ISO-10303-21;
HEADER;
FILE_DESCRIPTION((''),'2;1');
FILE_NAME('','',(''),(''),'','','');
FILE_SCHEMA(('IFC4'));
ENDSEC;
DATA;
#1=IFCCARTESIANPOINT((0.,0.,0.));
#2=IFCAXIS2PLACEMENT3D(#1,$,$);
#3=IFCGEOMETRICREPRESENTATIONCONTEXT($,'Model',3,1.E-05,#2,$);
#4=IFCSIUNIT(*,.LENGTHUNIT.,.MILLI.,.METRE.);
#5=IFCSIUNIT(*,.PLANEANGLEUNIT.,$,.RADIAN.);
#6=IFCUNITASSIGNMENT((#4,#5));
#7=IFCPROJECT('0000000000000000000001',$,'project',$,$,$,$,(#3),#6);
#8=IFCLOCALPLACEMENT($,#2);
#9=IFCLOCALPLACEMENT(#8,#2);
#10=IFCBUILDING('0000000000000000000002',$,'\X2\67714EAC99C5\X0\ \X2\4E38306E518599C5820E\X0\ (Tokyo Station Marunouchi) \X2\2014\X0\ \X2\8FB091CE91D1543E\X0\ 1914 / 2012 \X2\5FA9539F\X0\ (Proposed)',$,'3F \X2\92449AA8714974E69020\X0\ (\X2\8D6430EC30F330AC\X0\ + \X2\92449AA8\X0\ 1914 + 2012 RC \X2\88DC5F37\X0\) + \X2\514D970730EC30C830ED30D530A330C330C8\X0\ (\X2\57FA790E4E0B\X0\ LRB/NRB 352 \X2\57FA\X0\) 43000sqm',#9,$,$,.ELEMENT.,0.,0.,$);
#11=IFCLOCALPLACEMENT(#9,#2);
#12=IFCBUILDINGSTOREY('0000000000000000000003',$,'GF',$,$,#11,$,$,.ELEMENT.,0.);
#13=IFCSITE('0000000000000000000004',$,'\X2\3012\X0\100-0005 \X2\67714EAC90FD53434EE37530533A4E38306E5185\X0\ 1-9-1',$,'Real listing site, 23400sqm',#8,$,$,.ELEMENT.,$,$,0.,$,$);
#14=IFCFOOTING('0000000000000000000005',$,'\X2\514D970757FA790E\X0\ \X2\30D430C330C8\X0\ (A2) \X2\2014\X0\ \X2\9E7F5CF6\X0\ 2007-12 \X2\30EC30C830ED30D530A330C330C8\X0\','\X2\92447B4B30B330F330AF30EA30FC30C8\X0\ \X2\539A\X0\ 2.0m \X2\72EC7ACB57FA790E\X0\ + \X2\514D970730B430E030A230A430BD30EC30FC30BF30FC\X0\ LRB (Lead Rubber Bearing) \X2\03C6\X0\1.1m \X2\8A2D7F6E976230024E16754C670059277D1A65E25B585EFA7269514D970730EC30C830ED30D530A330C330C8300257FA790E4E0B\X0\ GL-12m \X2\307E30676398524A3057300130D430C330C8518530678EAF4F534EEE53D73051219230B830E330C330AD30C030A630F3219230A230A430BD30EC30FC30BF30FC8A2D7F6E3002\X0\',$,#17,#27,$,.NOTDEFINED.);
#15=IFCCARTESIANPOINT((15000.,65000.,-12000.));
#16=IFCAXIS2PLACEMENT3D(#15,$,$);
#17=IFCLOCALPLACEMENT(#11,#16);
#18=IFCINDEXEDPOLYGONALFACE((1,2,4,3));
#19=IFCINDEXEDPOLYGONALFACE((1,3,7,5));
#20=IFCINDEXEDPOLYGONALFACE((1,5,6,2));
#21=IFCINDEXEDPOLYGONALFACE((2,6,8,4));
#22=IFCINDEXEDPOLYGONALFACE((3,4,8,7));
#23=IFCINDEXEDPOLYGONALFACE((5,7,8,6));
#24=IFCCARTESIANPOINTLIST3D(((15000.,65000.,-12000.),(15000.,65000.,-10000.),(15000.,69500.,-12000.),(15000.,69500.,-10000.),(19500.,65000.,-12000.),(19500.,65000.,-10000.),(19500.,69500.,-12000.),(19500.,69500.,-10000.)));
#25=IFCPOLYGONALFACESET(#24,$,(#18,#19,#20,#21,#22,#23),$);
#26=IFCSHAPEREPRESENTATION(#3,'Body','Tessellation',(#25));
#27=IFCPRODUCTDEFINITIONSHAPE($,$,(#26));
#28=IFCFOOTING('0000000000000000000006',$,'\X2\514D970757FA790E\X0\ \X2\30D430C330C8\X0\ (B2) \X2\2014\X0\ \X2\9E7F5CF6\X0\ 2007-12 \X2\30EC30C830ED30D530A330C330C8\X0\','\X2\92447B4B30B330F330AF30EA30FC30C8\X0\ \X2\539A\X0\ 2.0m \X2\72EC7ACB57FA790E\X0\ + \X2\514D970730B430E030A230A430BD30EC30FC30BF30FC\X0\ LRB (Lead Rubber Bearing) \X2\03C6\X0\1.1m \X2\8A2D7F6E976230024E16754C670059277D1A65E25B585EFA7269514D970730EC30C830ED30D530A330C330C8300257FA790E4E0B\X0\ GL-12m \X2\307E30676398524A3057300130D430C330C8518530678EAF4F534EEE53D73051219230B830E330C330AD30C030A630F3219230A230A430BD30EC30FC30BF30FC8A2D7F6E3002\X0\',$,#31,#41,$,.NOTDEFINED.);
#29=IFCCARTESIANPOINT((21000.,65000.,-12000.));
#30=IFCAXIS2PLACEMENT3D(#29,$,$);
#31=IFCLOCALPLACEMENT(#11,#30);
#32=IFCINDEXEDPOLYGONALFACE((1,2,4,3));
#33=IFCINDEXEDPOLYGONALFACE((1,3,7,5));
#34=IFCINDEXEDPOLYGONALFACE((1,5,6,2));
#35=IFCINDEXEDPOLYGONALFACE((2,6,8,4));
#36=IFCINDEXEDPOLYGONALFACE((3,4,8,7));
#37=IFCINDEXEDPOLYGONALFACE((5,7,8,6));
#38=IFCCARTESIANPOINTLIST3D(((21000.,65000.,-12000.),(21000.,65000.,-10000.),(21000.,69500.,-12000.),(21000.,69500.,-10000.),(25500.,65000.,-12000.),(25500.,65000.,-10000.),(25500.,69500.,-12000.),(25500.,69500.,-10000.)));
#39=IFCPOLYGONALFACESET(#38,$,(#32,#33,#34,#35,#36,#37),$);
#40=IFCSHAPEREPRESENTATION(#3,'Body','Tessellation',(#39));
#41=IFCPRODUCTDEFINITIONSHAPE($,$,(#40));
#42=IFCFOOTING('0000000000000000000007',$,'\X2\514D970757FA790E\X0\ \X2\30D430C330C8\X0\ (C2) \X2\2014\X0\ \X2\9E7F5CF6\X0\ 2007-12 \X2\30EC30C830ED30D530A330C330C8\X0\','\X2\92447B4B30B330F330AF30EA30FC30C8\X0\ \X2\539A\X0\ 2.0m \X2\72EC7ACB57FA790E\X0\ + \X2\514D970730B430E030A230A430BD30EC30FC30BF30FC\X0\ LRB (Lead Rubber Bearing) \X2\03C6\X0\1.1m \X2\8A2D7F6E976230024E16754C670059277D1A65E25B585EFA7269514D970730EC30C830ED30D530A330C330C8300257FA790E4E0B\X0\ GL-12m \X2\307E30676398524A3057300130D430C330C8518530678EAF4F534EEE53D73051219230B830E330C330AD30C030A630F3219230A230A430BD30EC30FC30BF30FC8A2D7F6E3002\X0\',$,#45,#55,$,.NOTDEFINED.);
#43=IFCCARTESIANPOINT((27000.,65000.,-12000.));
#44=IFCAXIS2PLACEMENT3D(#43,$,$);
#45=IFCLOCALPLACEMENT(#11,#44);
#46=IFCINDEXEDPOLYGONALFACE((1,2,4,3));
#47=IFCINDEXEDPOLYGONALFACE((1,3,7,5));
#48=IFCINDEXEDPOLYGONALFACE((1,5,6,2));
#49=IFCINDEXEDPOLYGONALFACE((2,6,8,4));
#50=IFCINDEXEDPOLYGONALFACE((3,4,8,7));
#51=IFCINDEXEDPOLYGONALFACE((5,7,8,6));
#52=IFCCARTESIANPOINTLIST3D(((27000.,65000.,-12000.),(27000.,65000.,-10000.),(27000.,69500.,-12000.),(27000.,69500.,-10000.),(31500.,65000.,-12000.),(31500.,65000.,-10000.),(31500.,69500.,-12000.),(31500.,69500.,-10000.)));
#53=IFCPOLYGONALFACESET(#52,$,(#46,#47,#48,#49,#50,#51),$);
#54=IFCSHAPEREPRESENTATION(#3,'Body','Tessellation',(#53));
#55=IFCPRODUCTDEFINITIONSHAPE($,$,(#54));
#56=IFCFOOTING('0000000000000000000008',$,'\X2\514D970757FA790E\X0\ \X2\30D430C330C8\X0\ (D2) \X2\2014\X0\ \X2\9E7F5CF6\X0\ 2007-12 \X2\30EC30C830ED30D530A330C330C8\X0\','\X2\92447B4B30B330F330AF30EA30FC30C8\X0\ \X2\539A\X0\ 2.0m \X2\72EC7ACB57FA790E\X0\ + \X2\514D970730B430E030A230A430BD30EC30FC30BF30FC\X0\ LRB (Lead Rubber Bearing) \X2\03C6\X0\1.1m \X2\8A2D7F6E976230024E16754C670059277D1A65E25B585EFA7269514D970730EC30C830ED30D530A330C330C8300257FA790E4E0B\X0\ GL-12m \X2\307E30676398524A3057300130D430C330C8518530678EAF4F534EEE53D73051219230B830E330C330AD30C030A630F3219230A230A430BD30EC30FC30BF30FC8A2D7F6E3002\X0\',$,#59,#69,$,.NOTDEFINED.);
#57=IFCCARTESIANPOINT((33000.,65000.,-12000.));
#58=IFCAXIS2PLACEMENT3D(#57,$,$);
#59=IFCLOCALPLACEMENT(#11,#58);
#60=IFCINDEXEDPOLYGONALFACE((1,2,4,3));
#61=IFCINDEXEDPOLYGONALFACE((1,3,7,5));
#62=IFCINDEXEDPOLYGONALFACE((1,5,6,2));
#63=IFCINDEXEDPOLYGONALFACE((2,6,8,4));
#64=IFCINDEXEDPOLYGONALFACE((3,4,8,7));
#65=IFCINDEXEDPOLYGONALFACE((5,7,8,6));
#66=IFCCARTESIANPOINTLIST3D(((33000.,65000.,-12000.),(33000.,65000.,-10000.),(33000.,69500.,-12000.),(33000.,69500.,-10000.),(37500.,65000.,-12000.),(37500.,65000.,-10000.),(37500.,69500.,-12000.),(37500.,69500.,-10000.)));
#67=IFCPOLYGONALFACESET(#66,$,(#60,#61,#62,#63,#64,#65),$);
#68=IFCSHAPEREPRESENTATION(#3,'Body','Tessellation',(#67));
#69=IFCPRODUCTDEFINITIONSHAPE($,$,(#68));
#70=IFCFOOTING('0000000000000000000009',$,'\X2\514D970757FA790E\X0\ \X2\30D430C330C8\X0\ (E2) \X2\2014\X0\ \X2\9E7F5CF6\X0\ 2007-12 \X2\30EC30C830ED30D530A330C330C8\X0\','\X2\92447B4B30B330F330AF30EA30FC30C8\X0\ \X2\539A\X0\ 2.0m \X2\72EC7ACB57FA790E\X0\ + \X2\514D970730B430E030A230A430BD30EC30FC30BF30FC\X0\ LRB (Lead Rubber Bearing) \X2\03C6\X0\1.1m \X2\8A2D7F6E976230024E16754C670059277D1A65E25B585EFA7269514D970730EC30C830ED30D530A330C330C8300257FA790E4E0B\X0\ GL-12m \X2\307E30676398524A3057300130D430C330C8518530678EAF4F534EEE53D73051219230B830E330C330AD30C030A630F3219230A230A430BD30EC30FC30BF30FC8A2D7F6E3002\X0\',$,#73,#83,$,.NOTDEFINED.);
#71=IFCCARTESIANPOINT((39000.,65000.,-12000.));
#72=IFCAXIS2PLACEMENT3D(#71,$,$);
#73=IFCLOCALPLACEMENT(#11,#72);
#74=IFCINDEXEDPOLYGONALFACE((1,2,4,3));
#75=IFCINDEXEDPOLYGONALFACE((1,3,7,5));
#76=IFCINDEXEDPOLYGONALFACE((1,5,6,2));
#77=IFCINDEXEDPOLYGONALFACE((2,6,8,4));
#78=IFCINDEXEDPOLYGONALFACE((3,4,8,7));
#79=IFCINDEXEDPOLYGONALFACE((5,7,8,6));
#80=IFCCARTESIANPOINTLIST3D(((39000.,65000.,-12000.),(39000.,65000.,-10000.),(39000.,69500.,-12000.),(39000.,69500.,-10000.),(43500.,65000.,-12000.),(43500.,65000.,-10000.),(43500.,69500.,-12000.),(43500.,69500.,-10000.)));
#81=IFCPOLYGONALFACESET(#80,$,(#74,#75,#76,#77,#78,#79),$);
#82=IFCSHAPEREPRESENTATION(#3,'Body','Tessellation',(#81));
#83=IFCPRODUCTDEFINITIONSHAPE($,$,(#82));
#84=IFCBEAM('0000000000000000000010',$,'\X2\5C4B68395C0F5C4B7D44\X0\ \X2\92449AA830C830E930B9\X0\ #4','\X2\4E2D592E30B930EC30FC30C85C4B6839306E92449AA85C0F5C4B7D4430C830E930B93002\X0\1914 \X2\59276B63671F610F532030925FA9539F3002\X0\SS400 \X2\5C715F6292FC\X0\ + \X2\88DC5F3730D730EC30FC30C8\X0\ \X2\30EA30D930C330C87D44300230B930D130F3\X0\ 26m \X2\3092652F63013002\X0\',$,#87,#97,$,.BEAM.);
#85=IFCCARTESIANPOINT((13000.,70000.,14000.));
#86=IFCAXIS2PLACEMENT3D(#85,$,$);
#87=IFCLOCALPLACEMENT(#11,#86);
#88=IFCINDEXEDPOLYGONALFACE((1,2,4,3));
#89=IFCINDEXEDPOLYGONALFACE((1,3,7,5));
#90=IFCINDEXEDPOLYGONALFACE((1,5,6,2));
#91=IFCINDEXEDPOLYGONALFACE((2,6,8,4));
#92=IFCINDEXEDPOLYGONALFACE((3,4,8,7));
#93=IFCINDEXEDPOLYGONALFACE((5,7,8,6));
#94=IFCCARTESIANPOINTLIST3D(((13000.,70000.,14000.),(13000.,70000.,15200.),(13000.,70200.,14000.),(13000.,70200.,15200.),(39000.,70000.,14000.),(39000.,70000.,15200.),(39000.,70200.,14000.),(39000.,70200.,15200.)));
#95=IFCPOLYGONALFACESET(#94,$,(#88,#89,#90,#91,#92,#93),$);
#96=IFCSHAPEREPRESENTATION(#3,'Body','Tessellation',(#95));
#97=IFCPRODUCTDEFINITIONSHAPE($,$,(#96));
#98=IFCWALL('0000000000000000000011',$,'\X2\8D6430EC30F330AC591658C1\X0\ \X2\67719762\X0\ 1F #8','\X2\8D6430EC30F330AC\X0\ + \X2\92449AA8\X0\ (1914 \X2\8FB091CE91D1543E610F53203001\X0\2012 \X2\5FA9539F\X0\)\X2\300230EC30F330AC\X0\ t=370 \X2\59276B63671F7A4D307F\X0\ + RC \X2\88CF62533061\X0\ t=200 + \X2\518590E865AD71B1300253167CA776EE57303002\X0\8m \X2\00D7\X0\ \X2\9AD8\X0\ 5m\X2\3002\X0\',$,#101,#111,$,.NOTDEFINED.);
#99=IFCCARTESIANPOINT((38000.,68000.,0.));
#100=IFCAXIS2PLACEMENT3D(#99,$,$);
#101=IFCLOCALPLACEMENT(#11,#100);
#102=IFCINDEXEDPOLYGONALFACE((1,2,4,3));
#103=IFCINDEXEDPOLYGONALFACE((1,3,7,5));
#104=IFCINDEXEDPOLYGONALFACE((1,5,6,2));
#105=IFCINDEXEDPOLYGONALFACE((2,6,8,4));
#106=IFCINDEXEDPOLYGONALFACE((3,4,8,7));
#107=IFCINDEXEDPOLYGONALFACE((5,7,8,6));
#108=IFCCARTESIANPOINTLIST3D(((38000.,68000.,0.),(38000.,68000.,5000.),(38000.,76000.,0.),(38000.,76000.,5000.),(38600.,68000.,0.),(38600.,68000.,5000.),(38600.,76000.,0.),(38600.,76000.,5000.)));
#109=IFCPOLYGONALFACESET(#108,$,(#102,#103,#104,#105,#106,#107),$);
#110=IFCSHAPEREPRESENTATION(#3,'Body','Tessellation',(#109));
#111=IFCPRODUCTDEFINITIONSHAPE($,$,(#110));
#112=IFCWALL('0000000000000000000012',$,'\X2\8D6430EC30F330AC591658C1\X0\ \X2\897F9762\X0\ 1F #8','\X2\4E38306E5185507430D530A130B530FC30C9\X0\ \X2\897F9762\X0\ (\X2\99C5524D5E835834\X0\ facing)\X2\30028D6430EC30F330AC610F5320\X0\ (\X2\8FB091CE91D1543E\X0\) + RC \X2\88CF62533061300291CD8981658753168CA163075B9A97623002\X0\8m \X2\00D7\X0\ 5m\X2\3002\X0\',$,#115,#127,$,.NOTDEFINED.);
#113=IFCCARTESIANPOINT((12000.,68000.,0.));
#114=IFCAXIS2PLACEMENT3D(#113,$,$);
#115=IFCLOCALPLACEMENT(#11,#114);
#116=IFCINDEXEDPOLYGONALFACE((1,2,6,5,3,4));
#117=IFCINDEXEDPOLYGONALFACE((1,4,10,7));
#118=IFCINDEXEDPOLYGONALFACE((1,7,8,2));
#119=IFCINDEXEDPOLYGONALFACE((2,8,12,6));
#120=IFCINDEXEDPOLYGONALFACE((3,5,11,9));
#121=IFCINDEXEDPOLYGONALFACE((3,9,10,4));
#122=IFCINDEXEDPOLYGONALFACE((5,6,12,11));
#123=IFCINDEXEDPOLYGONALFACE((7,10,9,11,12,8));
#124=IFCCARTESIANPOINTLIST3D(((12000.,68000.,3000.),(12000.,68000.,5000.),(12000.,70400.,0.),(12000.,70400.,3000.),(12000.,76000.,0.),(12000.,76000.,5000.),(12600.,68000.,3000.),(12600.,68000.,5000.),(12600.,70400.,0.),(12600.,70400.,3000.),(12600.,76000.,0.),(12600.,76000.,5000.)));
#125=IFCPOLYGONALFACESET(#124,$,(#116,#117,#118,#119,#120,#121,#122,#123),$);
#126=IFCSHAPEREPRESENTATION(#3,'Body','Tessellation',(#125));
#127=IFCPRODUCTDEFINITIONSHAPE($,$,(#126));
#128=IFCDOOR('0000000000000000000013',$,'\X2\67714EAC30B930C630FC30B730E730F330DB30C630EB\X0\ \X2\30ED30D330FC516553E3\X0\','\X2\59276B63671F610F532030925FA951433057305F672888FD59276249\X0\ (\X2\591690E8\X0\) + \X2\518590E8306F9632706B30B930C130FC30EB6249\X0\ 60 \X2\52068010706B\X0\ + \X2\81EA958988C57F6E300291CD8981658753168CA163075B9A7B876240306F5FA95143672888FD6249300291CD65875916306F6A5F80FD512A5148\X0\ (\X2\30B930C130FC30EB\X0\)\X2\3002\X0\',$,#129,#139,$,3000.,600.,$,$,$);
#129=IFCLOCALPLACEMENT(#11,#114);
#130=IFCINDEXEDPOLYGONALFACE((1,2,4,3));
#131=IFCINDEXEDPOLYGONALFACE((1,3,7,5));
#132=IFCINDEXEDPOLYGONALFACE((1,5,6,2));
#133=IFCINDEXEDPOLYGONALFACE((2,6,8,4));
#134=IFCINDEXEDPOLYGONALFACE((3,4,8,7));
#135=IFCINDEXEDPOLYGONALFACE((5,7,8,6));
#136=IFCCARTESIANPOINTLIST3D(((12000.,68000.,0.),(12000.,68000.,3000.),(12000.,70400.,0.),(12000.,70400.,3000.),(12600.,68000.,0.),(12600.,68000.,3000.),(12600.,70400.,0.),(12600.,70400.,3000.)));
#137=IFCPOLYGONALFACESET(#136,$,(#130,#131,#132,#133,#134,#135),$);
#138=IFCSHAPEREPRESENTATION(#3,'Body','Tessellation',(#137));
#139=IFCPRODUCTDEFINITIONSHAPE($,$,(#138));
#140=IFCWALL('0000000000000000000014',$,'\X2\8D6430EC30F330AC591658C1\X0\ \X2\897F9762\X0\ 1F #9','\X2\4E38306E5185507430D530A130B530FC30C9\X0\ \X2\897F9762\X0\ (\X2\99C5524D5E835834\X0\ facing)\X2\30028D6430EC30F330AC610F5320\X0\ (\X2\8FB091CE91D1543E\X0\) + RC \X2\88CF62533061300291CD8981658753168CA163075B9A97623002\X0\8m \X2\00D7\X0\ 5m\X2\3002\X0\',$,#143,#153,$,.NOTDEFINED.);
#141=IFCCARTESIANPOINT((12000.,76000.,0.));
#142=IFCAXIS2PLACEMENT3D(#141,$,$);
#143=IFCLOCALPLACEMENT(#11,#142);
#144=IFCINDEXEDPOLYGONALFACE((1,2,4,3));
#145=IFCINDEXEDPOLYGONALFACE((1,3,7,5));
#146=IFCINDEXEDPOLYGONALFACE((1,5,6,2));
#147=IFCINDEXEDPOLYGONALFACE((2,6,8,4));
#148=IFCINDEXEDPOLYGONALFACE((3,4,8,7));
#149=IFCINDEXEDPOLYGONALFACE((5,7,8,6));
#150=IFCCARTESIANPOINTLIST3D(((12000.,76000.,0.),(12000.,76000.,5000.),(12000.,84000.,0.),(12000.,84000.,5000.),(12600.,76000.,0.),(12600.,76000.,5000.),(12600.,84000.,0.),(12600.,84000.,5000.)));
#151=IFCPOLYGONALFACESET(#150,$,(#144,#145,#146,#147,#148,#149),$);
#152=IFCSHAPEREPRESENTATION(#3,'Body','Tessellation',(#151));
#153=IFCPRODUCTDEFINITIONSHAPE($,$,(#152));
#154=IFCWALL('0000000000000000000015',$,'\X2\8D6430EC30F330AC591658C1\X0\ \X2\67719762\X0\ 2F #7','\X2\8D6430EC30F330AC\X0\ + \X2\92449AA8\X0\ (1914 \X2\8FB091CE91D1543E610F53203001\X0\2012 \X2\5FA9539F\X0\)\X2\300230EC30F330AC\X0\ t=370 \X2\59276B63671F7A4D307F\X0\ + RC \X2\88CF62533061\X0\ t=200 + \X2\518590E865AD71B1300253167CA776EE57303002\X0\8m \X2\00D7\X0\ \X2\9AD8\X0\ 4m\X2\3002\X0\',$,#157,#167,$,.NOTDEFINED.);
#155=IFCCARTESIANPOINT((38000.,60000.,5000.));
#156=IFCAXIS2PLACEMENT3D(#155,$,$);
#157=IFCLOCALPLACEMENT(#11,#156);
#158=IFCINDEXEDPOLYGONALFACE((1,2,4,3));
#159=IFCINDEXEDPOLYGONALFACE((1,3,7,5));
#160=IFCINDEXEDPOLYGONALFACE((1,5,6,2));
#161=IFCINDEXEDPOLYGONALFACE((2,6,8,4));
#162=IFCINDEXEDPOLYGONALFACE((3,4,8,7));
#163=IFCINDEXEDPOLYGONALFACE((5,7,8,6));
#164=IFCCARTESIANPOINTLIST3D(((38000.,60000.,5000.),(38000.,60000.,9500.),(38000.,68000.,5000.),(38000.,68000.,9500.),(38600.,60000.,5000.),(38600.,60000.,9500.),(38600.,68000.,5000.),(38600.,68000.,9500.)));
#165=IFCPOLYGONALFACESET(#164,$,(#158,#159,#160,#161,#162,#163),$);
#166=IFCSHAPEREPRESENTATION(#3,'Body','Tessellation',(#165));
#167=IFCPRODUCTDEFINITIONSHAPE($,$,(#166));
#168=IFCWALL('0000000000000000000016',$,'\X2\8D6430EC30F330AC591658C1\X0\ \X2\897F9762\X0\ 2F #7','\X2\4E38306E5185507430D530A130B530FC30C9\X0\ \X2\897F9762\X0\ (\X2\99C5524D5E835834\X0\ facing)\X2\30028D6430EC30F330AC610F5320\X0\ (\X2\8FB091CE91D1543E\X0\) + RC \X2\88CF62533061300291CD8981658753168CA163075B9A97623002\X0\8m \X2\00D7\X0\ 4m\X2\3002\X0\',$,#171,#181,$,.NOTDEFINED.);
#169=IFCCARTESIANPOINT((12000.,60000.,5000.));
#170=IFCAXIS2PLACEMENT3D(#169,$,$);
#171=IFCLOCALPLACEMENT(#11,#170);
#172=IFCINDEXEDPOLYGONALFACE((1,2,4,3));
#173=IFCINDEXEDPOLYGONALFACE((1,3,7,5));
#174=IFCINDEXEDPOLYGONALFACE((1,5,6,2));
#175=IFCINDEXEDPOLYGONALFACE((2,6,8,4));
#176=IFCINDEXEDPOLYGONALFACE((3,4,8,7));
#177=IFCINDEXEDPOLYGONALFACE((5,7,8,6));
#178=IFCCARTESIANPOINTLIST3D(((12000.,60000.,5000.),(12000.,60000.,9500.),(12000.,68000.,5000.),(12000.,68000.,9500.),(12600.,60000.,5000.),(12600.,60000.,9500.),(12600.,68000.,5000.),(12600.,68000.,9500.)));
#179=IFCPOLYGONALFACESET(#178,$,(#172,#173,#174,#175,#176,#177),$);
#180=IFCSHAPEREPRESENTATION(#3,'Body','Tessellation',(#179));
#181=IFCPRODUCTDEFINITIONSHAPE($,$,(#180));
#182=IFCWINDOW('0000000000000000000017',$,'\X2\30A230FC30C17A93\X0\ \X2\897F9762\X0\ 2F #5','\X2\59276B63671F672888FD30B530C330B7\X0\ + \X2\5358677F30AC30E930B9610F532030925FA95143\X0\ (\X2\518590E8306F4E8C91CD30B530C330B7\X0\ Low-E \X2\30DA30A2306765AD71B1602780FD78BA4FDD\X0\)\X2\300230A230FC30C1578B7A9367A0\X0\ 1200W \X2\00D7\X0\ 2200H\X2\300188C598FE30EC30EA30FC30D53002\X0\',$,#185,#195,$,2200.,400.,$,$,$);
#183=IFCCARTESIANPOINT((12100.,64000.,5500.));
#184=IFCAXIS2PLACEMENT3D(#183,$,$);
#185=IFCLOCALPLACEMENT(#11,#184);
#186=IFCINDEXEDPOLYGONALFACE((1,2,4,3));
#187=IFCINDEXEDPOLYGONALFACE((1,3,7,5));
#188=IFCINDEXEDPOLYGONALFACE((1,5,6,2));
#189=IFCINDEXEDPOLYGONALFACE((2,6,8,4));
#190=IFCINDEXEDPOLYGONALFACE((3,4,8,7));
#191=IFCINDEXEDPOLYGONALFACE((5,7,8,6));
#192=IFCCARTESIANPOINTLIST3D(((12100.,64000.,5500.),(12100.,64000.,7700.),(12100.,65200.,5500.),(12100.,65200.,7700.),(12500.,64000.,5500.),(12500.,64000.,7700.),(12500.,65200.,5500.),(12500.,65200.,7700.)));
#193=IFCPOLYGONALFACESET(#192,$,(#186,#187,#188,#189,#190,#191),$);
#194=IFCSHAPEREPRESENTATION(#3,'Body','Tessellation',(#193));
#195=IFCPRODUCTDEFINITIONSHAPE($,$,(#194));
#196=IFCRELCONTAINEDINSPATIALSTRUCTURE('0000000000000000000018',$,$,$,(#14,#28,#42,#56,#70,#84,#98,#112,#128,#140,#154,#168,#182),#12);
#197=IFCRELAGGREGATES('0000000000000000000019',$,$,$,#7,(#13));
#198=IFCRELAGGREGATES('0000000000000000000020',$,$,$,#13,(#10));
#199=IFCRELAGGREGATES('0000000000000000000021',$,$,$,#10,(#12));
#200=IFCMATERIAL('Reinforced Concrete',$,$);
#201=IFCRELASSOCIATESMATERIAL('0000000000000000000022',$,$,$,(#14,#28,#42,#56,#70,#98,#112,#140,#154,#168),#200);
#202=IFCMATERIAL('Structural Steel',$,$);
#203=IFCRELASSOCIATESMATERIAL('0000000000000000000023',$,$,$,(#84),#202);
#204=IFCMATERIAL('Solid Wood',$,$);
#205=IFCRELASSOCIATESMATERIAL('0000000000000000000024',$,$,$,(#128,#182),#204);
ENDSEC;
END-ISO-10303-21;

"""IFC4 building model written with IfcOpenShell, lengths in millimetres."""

from ifc_helpers import new_model, si_unit, frame, frame_2d, origin, place, context, project, spatial, rectangle, extrude, material, element, fill, save


model = new_model("IFC4")

# Units and contexts
model_context = context("Model", 3, precision=1e-05, world=origin())
ifc_project = project(units=[si_unit("LENGTHUNIT", "METRE", prefix="MILLI"), si_unit("PLANEANGLEUNIT", "RADIAN")], contexts=[model_context])

# Site, building, storey
site_placement = place(None, origin())
site = spatial("IfcSite", under=ifc_project, at=site_placement, Name="〒100-0005 東京都千代田区丸の内 1-9-1", ObjectType="Real listing site, 23400sqm", CompositionType="ELEMENT", RefElevation=0.0)
building_placement = place(site_placement, origin())
building = spatial("IfcBuilding", under=site, at=building_placement, Name="東京駅 丸の内駅舎 (Tokyo Station Marunouchi) — 辰野金吾 1914 / 2012 復原 (Proposed)", ObjectType="3F 鉄骨煉瓦造 (赤レンガ + 鉄骨 1914 + 2012 RC 補強) + 免震レトロフィット (基礎下 LRB/NRB 352 基) 43000sqm", CompositionType="ELEMENT", ElevationOfRefHeight=0.0, ElevationOfTerrain=0.0)
storey_placement = place(building_placement, origin())
storey = spatial("IfcBuildingStorey", under=building, at=storey_placement, Name="GF", CompositionType="ELEMENT", Elevation=0.0)

# Footings
ifc_material_1 = material(Name="Reinforced Concrete")
footing_1_placement = place(storey_placement, frame((15000.0, 65000.0, -12000.0)))
element("IfcFooting", 1, at=footing_1_placement, inside=storey, material=ifc_material_1, Name="免震基礎 ピット (A2) — 鹿島 2007-12 レトロフィット", Description="鉄筋コンクリート 厚 2.0m 独立基礎 + 免震ゴムアイソレーター LRB (Lead Rubber Bearing) φ1.1m 設置面。世界最大級既存建物免震レトロフィット。基礎下 GL-12m まで掘削し、ピット内で躯体仮受け→ジャッキダウン→アイソレーター設置。", PredefinedType="NOTDEFINED", context=model_context, shape_type="SweptSolid", body=[
    extrude(rectangle(XDim=4500.0, YDim=4500.0, at=frame_2d((2250.0, 2250.0))), frame((15000.0, 65000.0, -12000.0)), (0.0, 0.0, 1.0), 2000.0),
])
footing_2_placement = place(storey_placement, frame((21000.0, 65000.0, -12000.0)))
element("IfcFooting", 2, at=footing_2_placement, inside=storey, material=ifc_material_1, Name="免震基礎 ピット (B2) — 鹿島 2007-12 レトロフィット", Description="鉄筋コンクリート 厚 2.0m 独立基礎 + 免震ゴムアイソレーター LRB (Lead Rubber Bearing) φ1.1m 設置面。世界最大級既存建物免震レトロフィット。基礎下 GL-12m まで掘削し、ピット内で躯体仮受け→ジャッキダウン→アイソレーター設置。", PredefinedType="NOTDEFINED", context=model_context, shape_type="SweptSolid", body=[
    extrude(rectangle(XDim=4500.0, YDim=4500.0, at=frame_2d((2250.0, 2250.0))), frame((21000.0, 65000.0, -12000.0)), (0.0, 0.0, 1.0), 2000.0),
])
footing_3_placement = place(storey_placement, frame((27000.0, 65000.0, -12000.0)))
element("IfcFooting", 3, at=footing_3_placement, inside=storey, material=ifc_material_1, Name="免震基礎 ピット (C2) — 鹿島 2007-12 レトロフィット", Description="鉄筋コンクリート 厚 2.0m 独立基礎 + 免震ゴムアイソレーター LRB (Lead Rubber Bearing) φ1.1m 設置面。世界最大級既存建物免震レトロフィット。基礎下 GL-12m まで掘削し、ピット内で躯体仮受け→ジャッキダウン→アイソレーター設置。", PredefinedType="NOTDEFINED", context=model_context, shape_type="SweptSolid", body=[
    extrude(rectangle(XDim=4500.0, YDim=4500.0, at=frame_2d((2250.0, 2250.0))), frame((27000.0, 65000.0, -12000.0)), (0.0, 0.0, 1.0), 2000.0),
])
footing_4_placement = place(storey_placement, frame((33000.0, 65000.0, -12000.0)))
element("IfcFooting", 4, at=footing_4_placement, inside=storey, material=ifc_material_1, Name="免震基礎 ピット (D2) — 鹿島 2007-12 レトロフィット", Description="鉄筋コンクリート 厚 2.0m 独立基礎 + 免震ゴムアイソレーター LRB (Lead Rubber Bearing) φ1.1m 設置面。世界最大級既存建物免震レトロフィット。基礎下 GL-12m まで掘削し、ピット内で躯体仮受け→ジャッキダウン→アイソレーター設置。", PredefinedType="NOTDEFINED", context=model_context, shape_type="SweptSolid", body=[
    extrude(rectangle(XDim=4500.0, YDim=4500.0, at=frame_2d((2250.0, 2250.0))), frame((33000.0, 65000.0, -12000.0)), (0.0, 0.0, 1.0), 2000.0),
])
footing_5_placement = place(storey_placement, frame((39000.0, 65000.0, -12000.0)))
element("IfcFooting", 5, at=footing_5_placement, inside=storey, material=ifc_material_1, Name="免震基礎 ピット (E2) — 鹿島 2007-12 レトロフィット", Description="鉄筋コンクリート 厚 2.0m 独立基礎 + 免震ゴムアイソレーター LRB (Lead Rubber Bearing) φ1.1m 設置面。世界最大級既存建物免震レトロフィット。基礎下 GL-12m まで掘削し、ピット内で躯体仮受け→ジャッキダウン→アイソレーター設置。", PredefinedType="NOTDEFINED", context=model_context, shape_type="SweptSolid", body=[
    extrude(rectangle(XDim=4500.0, YDim=4500.0, at=frame_2d((2250.0, 2250.0))), frame((39000.0, 65000.0, -12000.0)), (0.0, 0.0, 1.0), 2000.0),
])

# Beam
ifc_material_2 = material(Name="Structural Steel")
beam_placement = place(storey_placement, frame((13000.0, 70000.0, 14000.0)))
element("IfcBeam", 6, at=beam_placement, inside=storey, material=ifc_material_2, Name="屋根小屋組 鉄骨トラス #4", Description="中央スレート屋根の鉄骨小屋組トラス。1914 大正期意匠を復原。SS400 山形鋼 + 補強プレート リベット組。スパン 26m を支持。", PredefinedType="BEAM", context=model_context, shape_type="SweptSolid", body=[
    extrude(rectangle(XDim=26000.0, YDim=200.0, at=frame_2d((13000.0, 100.0))), frame((13000.0, 70000.0, 14000.0)), (0.0, 0.0, 1.0), 1200.0),
])

# Wall
wall_1_placement = place(storey_placement, frame((38000.0, 68000.0, 0.0)))
element("IfcWall", 7, at=wall_1_placement, inside=storey, material=ifc_material_1, Name="赤レンガ外壁 東面 1F #8", Description="赤レンガ + 鉄骨 (1914 辰野金吾意匠、2012 復原)。レンガ t=370 大正期積み + RC 裏打ち t=200 + 内部断熱。化粧目地。8m × 高 5m。", PredefinedType="NOTDEFINED", context=model_context, shape_type="SweptSolid", body=[
    extrude(rectangle(XDim=600.0, YDim=8000.0, at=frame_2d((300.0, 4000.0))), frame((38000.0, 68000.0, 0.0)), (0.0, 0.0, 1.0), 5000.0),
])

# Wall, opening, door
wall_2_placement = place(storey_placement, frame((12000.0, 68000.0, 0.0)))
wall_2 = element("IfcWall", 8, at=wall_2_placement, inside=storey, material=ifc_material_1, Name="赤レンガ外壁 西面 1F #8", Description="丸の内側ファサード 西面 (駅前広場 facing)。赤レンガ意匠 (辰野金吾) + RC 裏打ち。重要文化財指定面。8m × 5m。", PredefinedType="NOTDEFINED", context=model_context, shape_type="SweptSolid", body=[
    extrude(rectangle(XDim=600.0, YDim=8000.0, at=frame_2d((300.0, 4000.0))), frame((12000.0, 68000.0, 0.0)), (0.0, 0.0, 1.0), 5000.0),
])
opening_1_placement = place(storey_placement, frame((12000.0, 68000.0, 0.0)))
opening_1 = element("IfcOpeningElement", 9, at=opening_1_placement, cuts=wall_2, PredefinedType="NOTDEFINED", context=model_context, shape_type="SweptSolid", body=[
    extrude(rectangle(XDim=600.0, YDim=2400.0, at=frame_2d((300.0, 1200.0))), frame((12000.0, 68000.0, 0.0)), (0.0, 0.0, 1.0), 3000.0),
])
ifc_material_3 = material(Name="Solid Wood")
door_placement = place(storey_placement, frame((12000.0, 68000.0, 0.0)))
door = element("IfcDoor", 10, at=door_placement, inside=storey, material=ifc_material_3, Name="東京ステーションホテル ロビー入口", Description="大正期意匠を復元した木製大扉 (外部) + 内部は防火スチール扉 60 分耐火 + 自閉装置。重要文化財指定箇所は復元木製扉。重文外は機能優先 (スチール)。", OverallHeight=3000.0, OverallWidth=600.0, context=model_context, shape_type="SweptSolid", body=[
    extrude(rectangle(XDim=600.0, YDim=2400.0, at=frame_2d((300.0, 1200.0))), frame((12000.0, 68000.0, 0.0)), (0.0, 0.0, 1.0), 3000.0),
])
fill(opening_1, door)

# Walls
wall_3_placement = place(storey_placement, frame((12000.0, 76000.0, 0.0)))
element("IfcWall", 11, at=wall_3_placement, inside=storey, material=ifc_material_1, Name="赤レンガ外壁 西面 1F #9", Description="丸の内側ファサード 西面 (駅前広場 facing)。赤レンガ意匠 (辰野金吾) + RC 裏打ち。重要文化財指定面。8m × 5m。", PredefinedType="NOTDEFINED", context=model_context, shape_type="SweptSolid", body=[
    extrude(rectangle(XDim=600.0, YDim=8000.0, at=frame_2d((300.0, 4000.0))), frame((12000.0, 76000.0, 0.0)), (0.0, 0.0, 1.0), 5000.0),
])
wall_4_placement = place(storey_placement, frame((38000.0, 60000.0, 5000.0)))
element("IfcWall", 12, at=wall_4_placement, inside=storey, material=ifc_material_1, Name="赤レンガ外壁 東面 2F #7", Description="赤レンガ + 鉄骨 (1914 辰野金吾意匠、2012 復原)。レンガ t=370 大正期積み + RC 裏打ち t=200 + 内部断熱。化粧目地。8m × 高 4m。", PredefinedType="NOTDEFINED", context=model_context, shape_type="SweptSolid", body=[
    extrude(rectangle(XDim=600.0, YDim=8000.0, at=frame_2d((300.0, 4000.0))), frame((38000.0, 60000.0, 5000.0)), (0.0, 0.0, 1.0), 4500.0),
])

# Wall, opening, window
wall_5_placement = place(storey_placement, frame((12000.0, 60000.0, 5000.0)))
wall_5 = element("IfcWall", 13, at=wall_5_placement, inside=storey, material=ifc_material_1, Name="赤レンガ外壁 西面 2F #7", Description="丸の内側ファサード 西面 (駅前広場 facing)。赤レンガ意匠 (辰野金吾) + RC 裏打ち。重要文化財指定面。8m × 4m。", PredefinedType="NOTDEFINED", context=model_context, shape_type="SweptSolid", body=[
    extrude(rectangle(XDim=600.0, YDim=8000.0, at=frame_2d((300.0, 4000.0))), frame((12000.0, 60000.0, 5000.0)), (0.0, 0.0, 1.0), 4500.0),
])
opening_2_placement = place(storey_placement, frame((12100.0, 64000.0, 5500.0)))
opening_2 = element("IfcOpeningElement", 14, at=opening_2_placement, cuts=wall_5, PredefinedType="NOTDEFINED", context=model_context, shape_type="SweptSolid", body=[
    extrude(rectangle(XDim=400.0, YDim=1200.0, at=frame_2d((200.0, 600.0))), frame((12100.0, 64000.0, 5500.0)), (0.0, 0.0, 1.0), 2200.0),
])
window_1_placement = place(storey_placement, frame((12100.0, 64000.0, 5500.0)))
window_1 = element("IfcWindow", 15, at=window_1_placement, inside=storey, material=ifc_material_3, Name="アーチ窓 西面 2F #5", Description="大正期木製サッシ + 単板ガラス意匠を復元 (内部は二重サッシ Low-E ペアで断熱性能確保)。アーチ型窓枠 1200W × 2200H、装飾レリーフ。", OverallHeight=2200.0, OverallWidth=400.0, context=model_context, shape_type="SweptSolid", body=[
    extrude(rectangle(XDim=400.0, YDim=1200.0, at=frame_2d((200.0, 600.0))), frame((12100.0, 64000.0, 5500.0)), (0.0, 0.0, 1.0), 2200.0),
])
fill(opening_2, window_1)

save(model, "model.ifc")
